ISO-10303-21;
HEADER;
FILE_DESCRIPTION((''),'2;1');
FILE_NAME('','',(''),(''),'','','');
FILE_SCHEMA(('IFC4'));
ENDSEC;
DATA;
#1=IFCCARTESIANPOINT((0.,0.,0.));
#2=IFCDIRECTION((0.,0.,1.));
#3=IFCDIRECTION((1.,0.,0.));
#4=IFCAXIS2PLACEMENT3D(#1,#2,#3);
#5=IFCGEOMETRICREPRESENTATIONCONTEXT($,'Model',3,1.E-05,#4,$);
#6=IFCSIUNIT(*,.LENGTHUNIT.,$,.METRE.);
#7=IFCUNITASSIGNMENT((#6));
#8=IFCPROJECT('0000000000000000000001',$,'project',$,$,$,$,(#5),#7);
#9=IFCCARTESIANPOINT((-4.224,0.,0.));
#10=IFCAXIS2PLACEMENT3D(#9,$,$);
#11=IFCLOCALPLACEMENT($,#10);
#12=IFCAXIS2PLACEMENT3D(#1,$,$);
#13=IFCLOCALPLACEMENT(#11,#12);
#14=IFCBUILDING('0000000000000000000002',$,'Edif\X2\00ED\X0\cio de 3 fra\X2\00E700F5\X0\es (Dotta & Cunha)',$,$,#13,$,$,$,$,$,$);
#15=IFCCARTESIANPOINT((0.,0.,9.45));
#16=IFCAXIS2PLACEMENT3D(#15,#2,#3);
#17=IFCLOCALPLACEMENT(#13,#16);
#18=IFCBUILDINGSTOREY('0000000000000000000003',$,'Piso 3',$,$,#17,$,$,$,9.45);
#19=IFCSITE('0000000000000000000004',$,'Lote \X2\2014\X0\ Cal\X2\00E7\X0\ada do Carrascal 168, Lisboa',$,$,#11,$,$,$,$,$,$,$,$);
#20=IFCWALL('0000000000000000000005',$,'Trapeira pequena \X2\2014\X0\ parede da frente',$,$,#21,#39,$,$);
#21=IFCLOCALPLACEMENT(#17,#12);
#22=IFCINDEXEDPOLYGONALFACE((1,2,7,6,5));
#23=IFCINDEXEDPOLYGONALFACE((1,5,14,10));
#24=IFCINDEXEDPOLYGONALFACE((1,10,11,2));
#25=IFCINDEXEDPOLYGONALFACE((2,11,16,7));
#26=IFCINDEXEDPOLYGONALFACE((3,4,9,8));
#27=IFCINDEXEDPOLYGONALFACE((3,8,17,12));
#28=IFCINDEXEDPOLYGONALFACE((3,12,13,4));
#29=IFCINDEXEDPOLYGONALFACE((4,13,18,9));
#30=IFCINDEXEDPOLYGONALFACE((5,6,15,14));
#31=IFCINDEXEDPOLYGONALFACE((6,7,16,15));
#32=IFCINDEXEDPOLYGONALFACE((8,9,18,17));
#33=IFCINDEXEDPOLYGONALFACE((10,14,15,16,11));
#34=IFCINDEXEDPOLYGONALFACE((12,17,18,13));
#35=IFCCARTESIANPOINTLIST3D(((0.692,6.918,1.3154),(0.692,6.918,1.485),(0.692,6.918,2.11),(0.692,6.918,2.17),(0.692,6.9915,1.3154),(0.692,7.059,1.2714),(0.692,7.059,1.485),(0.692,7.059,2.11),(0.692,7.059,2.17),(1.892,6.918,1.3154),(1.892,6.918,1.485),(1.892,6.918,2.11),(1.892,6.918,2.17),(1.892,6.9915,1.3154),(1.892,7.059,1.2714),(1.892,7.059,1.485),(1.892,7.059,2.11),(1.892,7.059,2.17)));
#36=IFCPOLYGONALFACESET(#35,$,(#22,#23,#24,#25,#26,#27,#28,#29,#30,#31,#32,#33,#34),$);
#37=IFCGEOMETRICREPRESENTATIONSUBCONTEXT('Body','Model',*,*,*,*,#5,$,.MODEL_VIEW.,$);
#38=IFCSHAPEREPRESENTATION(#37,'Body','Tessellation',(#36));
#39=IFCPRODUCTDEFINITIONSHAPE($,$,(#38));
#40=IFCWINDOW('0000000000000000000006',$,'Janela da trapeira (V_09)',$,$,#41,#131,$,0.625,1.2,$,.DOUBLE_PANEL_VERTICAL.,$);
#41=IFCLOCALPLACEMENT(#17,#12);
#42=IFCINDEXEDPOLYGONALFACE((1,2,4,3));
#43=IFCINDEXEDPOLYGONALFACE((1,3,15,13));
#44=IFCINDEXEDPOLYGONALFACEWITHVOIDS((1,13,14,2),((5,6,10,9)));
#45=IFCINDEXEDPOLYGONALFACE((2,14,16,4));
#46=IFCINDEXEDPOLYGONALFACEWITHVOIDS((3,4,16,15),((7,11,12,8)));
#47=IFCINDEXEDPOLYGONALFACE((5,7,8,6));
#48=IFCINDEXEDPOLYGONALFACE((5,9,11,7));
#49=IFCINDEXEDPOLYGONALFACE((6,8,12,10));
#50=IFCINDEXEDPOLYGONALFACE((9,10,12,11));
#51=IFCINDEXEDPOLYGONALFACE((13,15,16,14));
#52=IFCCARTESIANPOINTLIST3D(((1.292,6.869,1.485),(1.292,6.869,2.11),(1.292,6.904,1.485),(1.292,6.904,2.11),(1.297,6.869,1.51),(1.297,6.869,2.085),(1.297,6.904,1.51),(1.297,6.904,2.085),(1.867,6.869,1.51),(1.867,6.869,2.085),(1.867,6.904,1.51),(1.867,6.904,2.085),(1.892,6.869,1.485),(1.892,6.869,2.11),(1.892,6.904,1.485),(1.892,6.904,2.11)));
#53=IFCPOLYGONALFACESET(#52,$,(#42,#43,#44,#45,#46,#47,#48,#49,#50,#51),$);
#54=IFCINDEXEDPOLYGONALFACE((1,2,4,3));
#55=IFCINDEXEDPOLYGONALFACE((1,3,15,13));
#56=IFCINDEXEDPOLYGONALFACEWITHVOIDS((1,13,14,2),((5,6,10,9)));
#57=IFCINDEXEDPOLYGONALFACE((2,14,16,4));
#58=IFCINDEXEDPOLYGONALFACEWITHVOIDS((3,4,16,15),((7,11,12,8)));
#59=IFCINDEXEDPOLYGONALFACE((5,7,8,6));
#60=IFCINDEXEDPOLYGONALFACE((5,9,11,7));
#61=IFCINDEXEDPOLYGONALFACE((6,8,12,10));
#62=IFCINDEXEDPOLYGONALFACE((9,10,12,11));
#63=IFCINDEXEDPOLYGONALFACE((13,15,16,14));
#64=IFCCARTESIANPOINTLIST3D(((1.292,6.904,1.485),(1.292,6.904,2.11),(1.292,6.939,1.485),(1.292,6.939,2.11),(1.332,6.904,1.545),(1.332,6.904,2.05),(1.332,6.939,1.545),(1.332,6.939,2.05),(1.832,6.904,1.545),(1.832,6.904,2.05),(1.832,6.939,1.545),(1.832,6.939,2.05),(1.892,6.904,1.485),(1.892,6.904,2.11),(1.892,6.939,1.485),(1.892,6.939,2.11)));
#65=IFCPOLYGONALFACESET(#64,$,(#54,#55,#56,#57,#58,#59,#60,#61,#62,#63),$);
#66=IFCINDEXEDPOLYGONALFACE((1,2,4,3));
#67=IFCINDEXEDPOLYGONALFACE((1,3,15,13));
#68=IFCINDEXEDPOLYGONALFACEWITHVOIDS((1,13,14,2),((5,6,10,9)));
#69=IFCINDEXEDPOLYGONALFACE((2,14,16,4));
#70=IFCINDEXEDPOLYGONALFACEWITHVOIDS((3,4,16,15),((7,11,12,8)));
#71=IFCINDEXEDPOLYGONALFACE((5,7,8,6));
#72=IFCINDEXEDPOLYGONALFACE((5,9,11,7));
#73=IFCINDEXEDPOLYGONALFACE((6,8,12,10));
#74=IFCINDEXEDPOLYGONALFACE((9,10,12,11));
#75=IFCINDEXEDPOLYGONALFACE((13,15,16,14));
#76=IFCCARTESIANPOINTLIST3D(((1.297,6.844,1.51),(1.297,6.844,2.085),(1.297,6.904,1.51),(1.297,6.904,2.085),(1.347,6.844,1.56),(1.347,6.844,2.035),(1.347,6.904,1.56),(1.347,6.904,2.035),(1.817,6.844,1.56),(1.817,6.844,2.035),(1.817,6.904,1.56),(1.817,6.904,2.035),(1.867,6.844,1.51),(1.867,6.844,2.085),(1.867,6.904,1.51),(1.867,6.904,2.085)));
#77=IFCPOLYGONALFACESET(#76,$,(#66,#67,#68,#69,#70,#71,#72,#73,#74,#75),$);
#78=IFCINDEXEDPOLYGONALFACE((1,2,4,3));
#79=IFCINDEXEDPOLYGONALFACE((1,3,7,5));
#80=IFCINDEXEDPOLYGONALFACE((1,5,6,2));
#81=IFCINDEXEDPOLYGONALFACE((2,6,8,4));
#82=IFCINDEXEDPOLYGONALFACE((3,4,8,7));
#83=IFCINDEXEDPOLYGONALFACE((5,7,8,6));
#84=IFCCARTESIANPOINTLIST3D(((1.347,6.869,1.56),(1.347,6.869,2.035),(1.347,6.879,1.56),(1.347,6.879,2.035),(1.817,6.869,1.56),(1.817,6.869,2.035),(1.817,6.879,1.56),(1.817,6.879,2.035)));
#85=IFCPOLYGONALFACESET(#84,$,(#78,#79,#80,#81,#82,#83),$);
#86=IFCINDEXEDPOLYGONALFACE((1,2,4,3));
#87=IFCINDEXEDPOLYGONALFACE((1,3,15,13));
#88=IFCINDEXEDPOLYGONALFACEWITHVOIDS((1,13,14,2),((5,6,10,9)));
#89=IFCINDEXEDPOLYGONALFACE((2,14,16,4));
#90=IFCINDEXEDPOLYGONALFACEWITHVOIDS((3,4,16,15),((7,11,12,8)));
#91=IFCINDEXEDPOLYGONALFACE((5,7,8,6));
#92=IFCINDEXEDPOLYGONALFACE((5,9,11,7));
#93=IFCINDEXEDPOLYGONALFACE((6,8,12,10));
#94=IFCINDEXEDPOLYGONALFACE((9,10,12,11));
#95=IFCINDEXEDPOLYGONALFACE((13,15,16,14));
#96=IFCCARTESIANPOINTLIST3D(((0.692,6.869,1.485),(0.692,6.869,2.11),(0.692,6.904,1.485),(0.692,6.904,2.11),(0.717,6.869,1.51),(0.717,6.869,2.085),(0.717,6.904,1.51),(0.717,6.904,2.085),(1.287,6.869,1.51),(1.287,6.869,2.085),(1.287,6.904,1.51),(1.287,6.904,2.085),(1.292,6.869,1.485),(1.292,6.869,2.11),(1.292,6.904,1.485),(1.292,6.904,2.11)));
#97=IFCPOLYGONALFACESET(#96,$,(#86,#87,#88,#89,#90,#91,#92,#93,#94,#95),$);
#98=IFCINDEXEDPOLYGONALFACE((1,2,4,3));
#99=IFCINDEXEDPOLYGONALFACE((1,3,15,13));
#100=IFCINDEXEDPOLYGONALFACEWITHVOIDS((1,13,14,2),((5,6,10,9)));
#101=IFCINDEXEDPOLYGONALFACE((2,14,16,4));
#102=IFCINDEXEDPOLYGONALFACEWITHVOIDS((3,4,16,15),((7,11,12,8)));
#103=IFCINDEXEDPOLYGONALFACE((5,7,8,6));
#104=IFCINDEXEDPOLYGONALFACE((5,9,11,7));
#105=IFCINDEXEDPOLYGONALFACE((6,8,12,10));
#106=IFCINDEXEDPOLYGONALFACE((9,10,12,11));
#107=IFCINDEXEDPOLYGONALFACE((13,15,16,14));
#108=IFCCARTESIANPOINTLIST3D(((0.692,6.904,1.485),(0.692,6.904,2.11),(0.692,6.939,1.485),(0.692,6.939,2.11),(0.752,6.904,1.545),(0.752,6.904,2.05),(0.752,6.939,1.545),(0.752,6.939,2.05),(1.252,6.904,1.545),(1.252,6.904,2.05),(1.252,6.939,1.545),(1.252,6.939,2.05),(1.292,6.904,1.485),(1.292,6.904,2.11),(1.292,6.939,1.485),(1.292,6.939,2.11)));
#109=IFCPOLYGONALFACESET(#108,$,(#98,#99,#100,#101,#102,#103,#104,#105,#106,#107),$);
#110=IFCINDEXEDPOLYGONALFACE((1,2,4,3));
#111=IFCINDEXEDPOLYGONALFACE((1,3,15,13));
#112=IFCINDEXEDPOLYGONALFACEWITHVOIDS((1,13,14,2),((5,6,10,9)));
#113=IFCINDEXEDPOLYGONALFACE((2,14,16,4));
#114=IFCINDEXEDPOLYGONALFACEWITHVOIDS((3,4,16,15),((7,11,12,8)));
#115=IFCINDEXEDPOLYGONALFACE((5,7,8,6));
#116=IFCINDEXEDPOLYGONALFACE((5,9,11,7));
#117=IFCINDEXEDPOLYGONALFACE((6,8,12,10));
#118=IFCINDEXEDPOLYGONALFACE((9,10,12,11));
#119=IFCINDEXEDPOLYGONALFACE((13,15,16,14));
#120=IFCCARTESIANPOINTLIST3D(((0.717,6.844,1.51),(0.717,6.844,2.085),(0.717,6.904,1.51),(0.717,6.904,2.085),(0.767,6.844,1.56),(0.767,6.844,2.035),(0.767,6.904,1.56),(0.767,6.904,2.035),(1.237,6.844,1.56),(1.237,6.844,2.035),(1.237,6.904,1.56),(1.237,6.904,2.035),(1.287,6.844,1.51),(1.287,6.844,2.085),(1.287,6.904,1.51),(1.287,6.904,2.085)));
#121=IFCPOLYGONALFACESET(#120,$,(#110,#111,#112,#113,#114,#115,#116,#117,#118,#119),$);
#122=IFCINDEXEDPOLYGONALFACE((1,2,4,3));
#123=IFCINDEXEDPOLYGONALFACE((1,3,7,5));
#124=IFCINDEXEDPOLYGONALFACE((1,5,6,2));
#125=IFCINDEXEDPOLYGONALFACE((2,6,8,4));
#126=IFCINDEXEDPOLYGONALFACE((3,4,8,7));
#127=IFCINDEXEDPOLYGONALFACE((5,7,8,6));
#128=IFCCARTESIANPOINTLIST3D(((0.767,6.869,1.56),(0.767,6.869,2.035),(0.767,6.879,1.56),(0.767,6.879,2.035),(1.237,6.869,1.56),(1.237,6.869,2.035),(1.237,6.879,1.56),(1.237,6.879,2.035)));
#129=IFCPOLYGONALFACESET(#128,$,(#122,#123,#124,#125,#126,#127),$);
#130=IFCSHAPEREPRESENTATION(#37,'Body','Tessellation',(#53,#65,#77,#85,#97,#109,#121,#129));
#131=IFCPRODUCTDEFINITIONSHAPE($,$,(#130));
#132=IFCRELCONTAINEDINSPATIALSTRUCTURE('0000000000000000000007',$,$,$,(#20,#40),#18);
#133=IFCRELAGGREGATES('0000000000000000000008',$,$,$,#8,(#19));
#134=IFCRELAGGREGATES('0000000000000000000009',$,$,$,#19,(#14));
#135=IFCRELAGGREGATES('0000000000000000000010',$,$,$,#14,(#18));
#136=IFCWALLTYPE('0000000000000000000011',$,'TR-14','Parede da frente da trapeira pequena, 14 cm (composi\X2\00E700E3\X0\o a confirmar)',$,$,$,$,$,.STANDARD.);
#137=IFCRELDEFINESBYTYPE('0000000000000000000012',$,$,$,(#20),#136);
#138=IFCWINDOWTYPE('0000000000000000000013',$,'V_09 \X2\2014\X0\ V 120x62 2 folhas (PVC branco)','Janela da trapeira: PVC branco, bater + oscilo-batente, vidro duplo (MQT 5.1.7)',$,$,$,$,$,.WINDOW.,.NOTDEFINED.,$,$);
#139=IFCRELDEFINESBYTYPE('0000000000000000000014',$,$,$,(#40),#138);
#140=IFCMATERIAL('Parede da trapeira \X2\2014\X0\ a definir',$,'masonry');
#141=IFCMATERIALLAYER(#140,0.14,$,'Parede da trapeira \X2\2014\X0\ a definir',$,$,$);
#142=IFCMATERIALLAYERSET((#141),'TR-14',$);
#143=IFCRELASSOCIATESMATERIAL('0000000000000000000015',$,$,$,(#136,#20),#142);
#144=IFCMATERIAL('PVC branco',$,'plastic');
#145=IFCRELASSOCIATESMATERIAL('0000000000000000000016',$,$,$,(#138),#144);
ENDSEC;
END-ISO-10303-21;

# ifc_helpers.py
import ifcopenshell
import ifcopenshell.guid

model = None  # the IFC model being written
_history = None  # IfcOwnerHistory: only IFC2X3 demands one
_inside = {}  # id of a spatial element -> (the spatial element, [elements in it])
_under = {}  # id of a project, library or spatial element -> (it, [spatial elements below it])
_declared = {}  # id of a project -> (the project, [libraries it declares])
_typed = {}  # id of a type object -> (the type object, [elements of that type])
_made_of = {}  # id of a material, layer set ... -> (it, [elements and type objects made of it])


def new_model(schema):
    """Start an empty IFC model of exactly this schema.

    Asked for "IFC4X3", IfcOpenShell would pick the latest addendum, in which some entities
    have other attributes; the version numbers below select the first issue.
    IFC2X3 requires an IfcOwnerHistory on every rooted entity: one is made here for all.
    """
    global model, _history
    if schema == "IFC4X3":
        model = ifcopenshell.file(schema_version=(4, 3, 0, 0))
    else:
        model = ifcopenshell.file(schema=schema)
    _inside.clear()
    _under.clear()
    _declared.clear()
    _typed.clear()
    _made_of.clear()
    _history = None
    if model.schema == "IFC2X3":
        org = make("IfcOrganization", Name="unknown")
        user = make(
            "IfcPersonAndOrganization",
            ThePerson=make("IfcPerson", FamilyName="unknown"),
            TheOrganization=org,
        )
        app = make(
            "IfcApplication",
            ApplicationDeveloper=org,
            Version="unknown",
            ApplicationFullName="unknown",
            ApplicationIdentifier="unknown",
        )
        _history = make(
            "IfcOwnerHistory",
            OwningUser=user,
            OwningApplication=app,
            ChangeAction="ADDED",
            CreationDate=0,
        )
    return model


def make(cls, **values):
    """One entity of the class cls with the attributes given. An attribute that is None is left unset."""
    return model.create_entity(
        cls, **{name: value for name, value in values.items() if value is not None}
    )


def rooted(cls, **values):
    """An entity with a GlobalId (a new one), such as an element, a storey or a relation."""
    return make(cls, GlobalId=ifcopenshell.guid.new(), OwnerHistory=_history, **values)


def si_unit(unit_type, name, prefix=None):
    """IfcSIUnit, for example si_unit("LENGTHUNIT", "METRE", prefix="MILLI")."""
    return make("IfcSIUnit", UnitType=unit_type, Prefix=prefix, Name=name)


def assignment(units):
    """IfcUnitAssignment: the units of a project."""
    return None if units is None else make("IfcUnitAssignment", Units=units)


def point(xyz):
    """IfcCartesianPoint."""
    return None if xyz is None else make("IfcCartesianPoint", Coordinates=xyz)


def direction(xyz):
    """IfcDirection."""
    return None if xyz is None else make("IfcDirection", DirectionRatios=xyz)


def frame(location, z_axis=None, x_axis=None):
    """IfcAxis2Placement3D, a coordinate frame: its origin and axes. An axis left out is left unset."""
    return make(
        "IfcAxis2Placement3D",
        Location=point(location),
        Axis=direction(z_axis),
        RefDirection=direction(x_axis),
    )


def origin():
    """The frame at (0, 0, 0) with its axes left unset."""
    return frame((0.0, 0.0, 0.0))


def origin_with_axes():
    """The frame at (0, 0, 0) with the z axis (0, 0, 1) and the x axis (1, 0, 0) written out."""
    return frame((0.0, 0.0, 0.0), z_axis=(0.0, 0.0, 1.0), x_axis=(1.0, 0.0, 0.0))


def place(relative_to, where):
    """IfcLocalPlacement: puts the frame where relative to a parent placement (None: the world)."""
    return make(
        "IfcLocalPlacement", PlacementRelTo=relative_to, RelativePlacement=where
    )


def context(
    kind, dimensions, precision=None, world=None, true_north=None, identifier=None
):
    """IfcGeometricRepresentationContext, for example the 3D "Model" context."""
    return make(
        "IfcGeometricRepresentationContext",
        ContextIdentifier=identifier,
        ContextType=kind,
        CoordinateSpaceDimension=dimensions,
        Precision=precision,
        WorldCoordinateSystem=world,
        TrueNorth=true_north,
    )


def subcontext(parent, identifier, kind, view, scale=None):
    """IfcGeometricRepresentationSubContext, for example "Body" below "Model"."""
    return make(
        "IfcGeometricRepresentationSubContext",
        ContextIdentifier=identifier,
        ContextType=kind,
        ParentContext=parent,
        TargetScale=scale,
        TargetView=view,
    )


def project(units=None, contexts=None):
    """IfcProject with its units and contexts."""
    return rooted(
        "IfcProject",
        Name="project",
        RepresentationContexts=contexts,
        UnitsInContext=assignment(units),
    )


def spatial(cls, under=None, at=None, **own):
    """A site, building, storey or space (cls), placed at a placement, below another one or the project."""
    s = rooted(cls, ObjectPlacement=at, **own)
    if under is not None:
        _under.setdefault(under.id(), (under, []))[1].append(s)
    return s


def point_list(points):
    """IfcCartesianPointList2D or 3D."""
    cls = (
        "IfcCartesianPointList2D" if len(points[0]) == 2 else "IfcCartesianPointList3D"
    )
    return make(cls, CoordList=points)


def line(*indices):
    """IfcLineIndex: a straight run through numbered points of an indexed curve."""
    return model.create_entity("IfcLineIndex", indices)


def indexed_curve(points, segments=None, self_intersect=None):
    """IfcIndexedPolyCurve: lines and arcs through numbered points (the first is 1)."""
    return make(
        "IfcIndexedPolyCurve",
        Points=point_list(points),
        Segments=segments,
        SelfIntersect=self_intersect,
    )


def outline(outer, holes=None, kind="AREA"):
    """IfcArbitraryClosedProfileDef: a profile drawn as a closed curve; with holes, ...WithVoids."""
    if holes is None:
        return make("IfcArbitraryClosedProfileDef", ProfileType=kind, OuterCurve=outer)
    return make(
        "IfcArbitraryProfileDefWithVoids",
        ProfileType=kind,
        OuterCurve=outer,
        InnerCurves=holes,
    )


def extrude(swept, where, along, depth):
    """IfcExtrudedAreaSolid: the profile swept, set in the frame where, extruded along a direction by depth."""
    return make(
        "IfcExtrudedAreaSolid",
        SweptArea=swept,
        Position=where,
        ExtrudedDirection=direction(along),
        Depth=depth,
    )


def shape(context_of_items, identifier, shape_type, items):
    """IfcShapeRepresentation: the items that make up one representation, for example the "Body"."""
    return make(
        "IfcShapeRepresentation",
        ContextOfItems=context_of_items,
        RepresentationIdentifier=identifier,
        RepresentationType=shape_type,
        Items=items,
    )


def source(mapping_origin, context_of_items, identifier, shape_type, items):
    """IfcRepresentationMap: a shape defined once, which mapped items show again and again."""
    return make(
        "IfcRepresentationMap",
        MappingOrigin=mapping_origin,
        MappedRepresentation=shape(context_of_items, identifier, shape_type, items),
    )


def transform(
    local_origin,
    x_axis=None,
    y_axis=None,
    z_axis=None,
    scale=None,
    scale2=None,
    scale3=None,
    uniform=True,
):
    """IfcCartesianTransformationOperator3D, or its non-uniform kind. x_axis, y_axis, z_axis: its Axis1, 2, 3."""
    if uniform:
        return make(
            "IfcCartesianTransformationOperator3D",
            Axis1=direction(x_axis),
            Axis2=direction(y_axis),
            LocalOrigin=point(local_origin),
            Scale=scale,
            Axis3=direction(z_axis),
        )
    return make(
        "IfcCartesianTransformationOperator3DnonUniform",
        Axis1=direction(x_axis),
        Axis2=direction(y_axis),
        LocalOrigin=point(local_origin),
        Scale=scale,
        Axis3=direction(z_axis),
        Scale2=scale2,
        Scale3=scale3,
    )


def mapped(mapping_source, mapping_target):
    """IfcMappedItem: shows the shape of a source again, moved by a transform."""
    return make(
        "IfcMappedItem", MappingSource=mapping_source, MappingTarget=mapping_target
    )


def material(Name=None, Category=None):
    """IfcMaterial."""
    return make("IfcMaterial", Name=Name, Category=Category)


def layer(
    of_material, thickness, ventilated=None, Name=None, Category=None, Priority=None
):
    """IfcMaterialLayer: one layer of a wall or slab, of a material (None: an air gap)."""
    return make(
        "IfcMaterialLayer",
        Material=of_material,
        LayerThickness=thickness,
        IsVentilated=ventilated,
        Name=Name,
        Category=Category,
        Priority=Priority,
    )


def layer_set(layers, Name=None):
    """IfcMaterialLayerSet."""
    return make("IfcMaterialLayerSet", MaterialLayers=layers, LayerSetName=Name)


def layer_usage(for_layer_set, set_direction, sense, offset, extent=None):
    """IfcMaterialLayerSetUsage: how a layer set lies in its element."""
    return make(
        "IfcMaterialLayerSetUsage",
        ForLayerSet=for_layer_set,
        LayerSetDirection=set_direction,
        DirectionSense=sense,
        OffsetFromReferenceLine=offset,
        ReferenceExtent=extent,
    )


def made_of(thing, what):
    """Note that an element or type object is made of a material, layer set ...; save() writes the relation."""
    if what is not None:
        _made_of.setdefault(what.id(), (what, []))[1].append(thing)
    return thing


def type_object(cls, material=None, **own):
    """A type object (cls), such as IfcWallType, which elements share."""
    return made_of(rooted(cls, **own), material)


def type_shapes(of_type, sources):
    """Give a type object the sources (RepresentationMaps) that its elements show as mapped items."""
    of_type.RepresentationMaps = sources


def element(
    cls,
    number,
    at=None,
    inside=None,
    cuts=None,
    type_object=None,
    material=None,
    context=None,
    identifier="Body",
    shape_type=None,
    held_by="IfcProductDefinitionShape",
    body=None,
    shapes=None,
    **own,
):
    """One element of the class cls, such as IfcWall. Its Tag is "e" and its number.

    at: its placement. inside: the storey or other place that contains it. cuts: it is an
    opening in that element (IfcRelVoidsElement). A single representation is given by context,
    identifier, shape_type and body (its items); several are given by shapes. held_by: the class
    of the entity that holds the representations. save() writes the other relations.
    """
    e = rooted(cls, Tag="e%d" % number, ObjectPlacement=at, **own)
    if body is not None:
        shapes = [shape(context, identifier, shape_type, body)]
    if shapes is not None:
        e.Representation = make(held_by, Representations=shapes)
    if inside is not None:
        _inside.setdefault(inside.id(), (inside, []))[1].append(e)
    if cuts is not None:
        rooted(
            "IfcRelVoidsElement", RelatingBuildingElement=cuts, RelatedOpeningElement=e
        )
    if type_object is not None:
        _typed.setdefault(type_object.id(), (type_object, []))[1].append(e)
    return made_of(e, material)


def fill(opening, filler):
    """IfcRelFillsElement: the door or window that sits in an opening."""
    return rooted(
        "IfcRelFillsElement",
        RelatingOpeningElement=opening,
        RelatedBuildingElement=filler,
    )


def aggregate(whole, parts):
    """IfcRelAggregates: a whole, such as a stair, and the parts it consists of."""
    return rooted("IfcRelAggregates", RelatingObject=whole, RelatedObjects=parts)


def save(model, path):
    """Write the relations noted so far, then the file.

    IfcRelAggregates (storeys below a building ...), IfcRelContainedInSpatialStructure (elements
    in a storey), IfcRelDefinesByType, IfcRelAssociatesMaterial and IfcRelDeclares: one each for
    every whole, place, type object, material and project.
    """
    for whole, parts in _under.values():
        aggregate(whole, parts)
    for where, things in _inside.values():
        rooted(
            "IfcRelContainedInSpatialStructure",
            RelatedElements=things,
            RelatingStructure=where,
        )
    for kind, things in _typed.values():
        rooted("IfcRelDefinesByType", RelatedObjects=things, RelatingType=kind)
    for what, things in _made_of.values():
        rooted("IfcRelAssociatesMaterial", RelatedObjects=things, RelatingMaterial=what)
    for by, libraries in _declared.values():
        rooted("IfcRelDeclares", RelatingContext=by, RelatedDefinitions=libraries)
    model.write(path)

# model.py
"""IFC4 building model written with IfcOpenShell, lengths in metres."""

from ifc_helpers import new_model, si_unit, frame, origin, origin_with_axes, place, context, subcontext, project, spatial, line, indexed_curve, outline, extrude, source, transform, mapped, material, layer, layer_set, layer_usage, type_object, type_shapes, element, fill, save


model = new_model("IFC4")

# Units and contexts
model_context = context("Model", 3, precision=1e-05, world=origin_with_axes())
body_context = subcontext(model_context, "Body", "Model", "MODEL_VIEW")
ifc_project = project(units=[si_unit("LENGTHUNIT", "METRE")], contexts=[model_context])

# Site, building, storey
site_placement = place(None, frame((-4.224, 0.0, 0.0)))
site = spatial("IfcSite", under=ifc_project, at=site_placement, Name="Lote — Calçada do Carrascal 168, Lisboa")
building_placement = place(site_placement, origin())
building = spatial("IfcBuilding", under=site, at=building_placement, Name="Edifício de 3 frações (Dotta & Cunha)")
storey_placement = place(building_placement, frame((0.0, 0.0, 9.45), z_axis=(0.0, 0.0, 1.0), x_axis=(1.0, 0.0, 0.0)))
storey = spatial("IfcBuildingStorey", under=building, at=storey_placement, Name="Piso 3", Elevation=9.45)

# Wall, opening, window
ifc_material_1 = material(Name="Parede da trapeira — a definir", Category="masonry")
ifc_layer_1 = layer(ifc_material_1, 0.14, Name="Parede da trapeira — a definir")
ifc_layer_set_1 = layer_set([ifc_layer_1], Name="TR-14")
ifc_layer_usage_1 = layer_usage(ifc_layer_set_1, "AXIS2", "POSITIVE", 0.0)
wall_type = type_object("IfcWallType", Name="TR-14", Description="Parede da frente da trapeira pequena, 14 cm (composição a confirmar)", PredefinedType="STANDARD", material=ifc_layer_set_1)
wall_placement = place(storey_placement, frame((0.692, 0.0, -9.45), z_axis=(1.0, 0.0, 0.0), x_axis=(0.0, 1.0, 0.0)))
wall = element("IfcWall", 1, at=wall_placement, inside=storey, type_object=wall_type, material=ifc_layer_usage_1, Name="Trapeira pequena — parede da frente", context=body_context, shape_type="SweptSolid", body=[
    extrude(outline(indexed_curve([(6.918, 10.7654), (6.9915, 10.7654), (7.059, 10.7214), (7.059, 11.62), (6.918, 11.62)], segments=[line(1, 2, 3, 4, 5, 1)])), origin_with_axes(), (0.0, 0.0, 1.0), 1.2),
])
opening_1_placement = place(wall_placement, frame((7.109, 0.0, -0.692), z_axis=(-1.0, 0.0, 0.0), x_axis=(0.0, 0.0, 1.0)))
opening_1 = element("IfcOpeningElement", 2, at=opening_1_placement, cuts=wall, context=body_context, shape_type="SweptSolid", body=[
    extrude(outline(indexed_curve([(1.892, 10.935), (1.892, 11.56), (0.692, 11.56), (0.692, 10.935)], segments=[line(1, 2, 3, 4, 1)])), origin_with_axes(), (0.0, 0.0, 1.0), 0.241),
])
ifc_material_2 = material(Name="PVC branco", Category="plastic")
window_type_1 = type_object("IfcWindowType", Name="V_09 — V 120x62 2 folhas (PVC branco)", Description="Janela da trapeira: PVC branco, bater + oscilo-batente, vidro duplo (MQT 5.1.7)", PartitioningType="NOTDEFINED", PredefinedType="WINDOW", material=ifc_material_2)
shared_shape_1 = source(origin_with_axes(), body_context, "Body", "SweptSolid", [
    extrude(outline(indexed_curve([(0.0, 0.0), (0.6, 0.0), (0.6, 0.625), (0.0, 0.625)], segments=[line(1, 2, 3, 4, 1)]), holes=[indexed_curve([(0.025, 0.025), (0.595, 0.025), (0.595, 0.6), (0.025, 0.6)], segments=[line(1, 2, 3, 4, 1)])]), frame((0.0, 0.035, 0.0), z_axis=(0.0, -1.0, 0.0), x_axis=(1.0, 0.0, 0.0)), (0.0, 0.0, -1.0), 0.035),
    extrude(outline(indexed_curve([(0.0, 0.0), (0.6, 0.0), (0.6, 0.625), (0.0, 0.625)], segments=[line(1, 2, 3, 4, 1)]), holes=[indexed_curve([(0.06, 0.06), (0.56, 0.06), (0.56, 0.565), (0.06, 0.565)], segments=[line(1, 2, 3, 4, 1)])]), frame((0.0, 0.0, 0.0), z_axis=(0.0, -1.0, 0.0), x_axis=(1.0, 0.0, 0.0)), (0.0, 0.0, -1.0), 0.035),
    extrude(outline(indexed_curve([(0.0, 0.0), (0.57, 0.0), (0.57, 0.575), (0.0, 0.575)], segments=[line(1, 2, 3, 4, 1)]), holes=[indexed_curve([(0.05, 0.05), (0.52, 0.05), (0.52, 0.525), (0.05, 0.525)], segments=[line(1, 2, 3, 4, 1)])]), frame((0.025, 0.035, 0.025), z_axis=(0.0, -1.0, 0.0), x_axis=(1.0, 0.0, 0.0)), (0.0, 0.0, -1.0), 0.06),
    extrude(outline(indexed_curve([(0.05, 0.05), (0.52, 0.05), (0.52, 0.525), (0.05, 0.525)], segments=[line(1, 2, 3, 4, 1)])), frame((0.025, 0.06, 0.025), z_axis=(0.0, -1.0, 0.0), x_axis=(1.0, 0.0, 0.0)), (0.0, 0.0, -1.0), 0.01),
    extrude(outline(indexed_curve([(0.0, 0.0), (0.6, 0.0), (0.6, 0.625), (0.0, 0.625)], segments=[line(1, 2, 3, 4, 1)]), holes=[indexed_curve([(0.005, 0.025), (0.575, 0.025), (0.575, 0.6), (0.005, 0.6)], segments=[line(1, 2, 3, 4, 1)])]), frame((0.6, 0.035, 0.0), z_axis=(0.0, -1.0, 0.0), x_axis=(1.0, 0.0, 0.0)), (0.0, 0.0, -1.0), 0.035),
    extrude(outline(indexed_curve([(0.0, 0.0), (0.6, 0.0), (0.6, 0.625), (0.0, 0.625)], segments=[line(1, 2, 3, 4, 1)]), holes=[indexed_curve([(0.04, 0.06), (0.54, 0.06), (0.54, 0.565), (0.04, 0.565)], segments=[line(1, 2, 3, 4, 1)])]), frame((0.6, 0.0, 0.0), z_axis=(0.0, -1.0, 0.0), x_axis=(1.0, 0.0, 0.0)), (0.0, 0.0, -1.0), 0.035),
    extrude(outline(indexed_curve([(0.0, 0.0), (0.57, 0.0), (0.57, 0.575), (0.0, 0.575)], segments=[line(1, 2, 3, 4, 1)]), holes=[indexed_curve([(0.05, 0.05), (0.52, 0.05), (0.52, 0.525), (0.05, 0.525)], segments=[line(1, 2, 3, 4, 1)])]), frame((0.605, 0.035, 0.025), z_axis=(0.0, -1.0, 0.0), x_axis=(1.0, 0.0, 0.0)), (0.0, 0.0, -1.0), 0.06),
    extrude(outline(indexed_curve([(0.05, 0.05), (0.52, 0.05), (0.52, 0.525), (0.05, 0.525)], segments=[line(1, 2, 3, 4, 1)])), frame((0.605, 0.06, 0.025), z_axis=(0.0, -1.0, 0.0), x_axis=(1.0, 0.0, 0.0)), (0.0, 0.0, -1.0), 0.01),
])
type_shapes(window_type_1, [shared_shape_1])
window_1_placement = place(storey_placement, frame((1.892, 6.939, 1.485), z_axis=(0.0, 0.0, 1.0), x_axis=(-1.0, 0.0, 0.0)))
window_1 = element("IfcWindow", 3, at=window_1_placement, inside=storey, type_object=window_type_1, Name="Janela da trapeira (V_09)", OverallHeight=0.625, OverallWidth=1.2, PartitioningType="DOUBLE_PANEL_VERTICAL", context=body_context, shape_type="MappedRepresentation", body=[
    mapped(shared_shape_1, transform((0.0, 0.0, 0.0), x_axis=(1.0, 0.0, 0.0), y_axis=(0.0, 1.0, 0.0), z_axis=(0.0, 0.0, 1.0), scale=1.0)),
])
fill(opening_1, window_1)

save(model, "model.ifc")
